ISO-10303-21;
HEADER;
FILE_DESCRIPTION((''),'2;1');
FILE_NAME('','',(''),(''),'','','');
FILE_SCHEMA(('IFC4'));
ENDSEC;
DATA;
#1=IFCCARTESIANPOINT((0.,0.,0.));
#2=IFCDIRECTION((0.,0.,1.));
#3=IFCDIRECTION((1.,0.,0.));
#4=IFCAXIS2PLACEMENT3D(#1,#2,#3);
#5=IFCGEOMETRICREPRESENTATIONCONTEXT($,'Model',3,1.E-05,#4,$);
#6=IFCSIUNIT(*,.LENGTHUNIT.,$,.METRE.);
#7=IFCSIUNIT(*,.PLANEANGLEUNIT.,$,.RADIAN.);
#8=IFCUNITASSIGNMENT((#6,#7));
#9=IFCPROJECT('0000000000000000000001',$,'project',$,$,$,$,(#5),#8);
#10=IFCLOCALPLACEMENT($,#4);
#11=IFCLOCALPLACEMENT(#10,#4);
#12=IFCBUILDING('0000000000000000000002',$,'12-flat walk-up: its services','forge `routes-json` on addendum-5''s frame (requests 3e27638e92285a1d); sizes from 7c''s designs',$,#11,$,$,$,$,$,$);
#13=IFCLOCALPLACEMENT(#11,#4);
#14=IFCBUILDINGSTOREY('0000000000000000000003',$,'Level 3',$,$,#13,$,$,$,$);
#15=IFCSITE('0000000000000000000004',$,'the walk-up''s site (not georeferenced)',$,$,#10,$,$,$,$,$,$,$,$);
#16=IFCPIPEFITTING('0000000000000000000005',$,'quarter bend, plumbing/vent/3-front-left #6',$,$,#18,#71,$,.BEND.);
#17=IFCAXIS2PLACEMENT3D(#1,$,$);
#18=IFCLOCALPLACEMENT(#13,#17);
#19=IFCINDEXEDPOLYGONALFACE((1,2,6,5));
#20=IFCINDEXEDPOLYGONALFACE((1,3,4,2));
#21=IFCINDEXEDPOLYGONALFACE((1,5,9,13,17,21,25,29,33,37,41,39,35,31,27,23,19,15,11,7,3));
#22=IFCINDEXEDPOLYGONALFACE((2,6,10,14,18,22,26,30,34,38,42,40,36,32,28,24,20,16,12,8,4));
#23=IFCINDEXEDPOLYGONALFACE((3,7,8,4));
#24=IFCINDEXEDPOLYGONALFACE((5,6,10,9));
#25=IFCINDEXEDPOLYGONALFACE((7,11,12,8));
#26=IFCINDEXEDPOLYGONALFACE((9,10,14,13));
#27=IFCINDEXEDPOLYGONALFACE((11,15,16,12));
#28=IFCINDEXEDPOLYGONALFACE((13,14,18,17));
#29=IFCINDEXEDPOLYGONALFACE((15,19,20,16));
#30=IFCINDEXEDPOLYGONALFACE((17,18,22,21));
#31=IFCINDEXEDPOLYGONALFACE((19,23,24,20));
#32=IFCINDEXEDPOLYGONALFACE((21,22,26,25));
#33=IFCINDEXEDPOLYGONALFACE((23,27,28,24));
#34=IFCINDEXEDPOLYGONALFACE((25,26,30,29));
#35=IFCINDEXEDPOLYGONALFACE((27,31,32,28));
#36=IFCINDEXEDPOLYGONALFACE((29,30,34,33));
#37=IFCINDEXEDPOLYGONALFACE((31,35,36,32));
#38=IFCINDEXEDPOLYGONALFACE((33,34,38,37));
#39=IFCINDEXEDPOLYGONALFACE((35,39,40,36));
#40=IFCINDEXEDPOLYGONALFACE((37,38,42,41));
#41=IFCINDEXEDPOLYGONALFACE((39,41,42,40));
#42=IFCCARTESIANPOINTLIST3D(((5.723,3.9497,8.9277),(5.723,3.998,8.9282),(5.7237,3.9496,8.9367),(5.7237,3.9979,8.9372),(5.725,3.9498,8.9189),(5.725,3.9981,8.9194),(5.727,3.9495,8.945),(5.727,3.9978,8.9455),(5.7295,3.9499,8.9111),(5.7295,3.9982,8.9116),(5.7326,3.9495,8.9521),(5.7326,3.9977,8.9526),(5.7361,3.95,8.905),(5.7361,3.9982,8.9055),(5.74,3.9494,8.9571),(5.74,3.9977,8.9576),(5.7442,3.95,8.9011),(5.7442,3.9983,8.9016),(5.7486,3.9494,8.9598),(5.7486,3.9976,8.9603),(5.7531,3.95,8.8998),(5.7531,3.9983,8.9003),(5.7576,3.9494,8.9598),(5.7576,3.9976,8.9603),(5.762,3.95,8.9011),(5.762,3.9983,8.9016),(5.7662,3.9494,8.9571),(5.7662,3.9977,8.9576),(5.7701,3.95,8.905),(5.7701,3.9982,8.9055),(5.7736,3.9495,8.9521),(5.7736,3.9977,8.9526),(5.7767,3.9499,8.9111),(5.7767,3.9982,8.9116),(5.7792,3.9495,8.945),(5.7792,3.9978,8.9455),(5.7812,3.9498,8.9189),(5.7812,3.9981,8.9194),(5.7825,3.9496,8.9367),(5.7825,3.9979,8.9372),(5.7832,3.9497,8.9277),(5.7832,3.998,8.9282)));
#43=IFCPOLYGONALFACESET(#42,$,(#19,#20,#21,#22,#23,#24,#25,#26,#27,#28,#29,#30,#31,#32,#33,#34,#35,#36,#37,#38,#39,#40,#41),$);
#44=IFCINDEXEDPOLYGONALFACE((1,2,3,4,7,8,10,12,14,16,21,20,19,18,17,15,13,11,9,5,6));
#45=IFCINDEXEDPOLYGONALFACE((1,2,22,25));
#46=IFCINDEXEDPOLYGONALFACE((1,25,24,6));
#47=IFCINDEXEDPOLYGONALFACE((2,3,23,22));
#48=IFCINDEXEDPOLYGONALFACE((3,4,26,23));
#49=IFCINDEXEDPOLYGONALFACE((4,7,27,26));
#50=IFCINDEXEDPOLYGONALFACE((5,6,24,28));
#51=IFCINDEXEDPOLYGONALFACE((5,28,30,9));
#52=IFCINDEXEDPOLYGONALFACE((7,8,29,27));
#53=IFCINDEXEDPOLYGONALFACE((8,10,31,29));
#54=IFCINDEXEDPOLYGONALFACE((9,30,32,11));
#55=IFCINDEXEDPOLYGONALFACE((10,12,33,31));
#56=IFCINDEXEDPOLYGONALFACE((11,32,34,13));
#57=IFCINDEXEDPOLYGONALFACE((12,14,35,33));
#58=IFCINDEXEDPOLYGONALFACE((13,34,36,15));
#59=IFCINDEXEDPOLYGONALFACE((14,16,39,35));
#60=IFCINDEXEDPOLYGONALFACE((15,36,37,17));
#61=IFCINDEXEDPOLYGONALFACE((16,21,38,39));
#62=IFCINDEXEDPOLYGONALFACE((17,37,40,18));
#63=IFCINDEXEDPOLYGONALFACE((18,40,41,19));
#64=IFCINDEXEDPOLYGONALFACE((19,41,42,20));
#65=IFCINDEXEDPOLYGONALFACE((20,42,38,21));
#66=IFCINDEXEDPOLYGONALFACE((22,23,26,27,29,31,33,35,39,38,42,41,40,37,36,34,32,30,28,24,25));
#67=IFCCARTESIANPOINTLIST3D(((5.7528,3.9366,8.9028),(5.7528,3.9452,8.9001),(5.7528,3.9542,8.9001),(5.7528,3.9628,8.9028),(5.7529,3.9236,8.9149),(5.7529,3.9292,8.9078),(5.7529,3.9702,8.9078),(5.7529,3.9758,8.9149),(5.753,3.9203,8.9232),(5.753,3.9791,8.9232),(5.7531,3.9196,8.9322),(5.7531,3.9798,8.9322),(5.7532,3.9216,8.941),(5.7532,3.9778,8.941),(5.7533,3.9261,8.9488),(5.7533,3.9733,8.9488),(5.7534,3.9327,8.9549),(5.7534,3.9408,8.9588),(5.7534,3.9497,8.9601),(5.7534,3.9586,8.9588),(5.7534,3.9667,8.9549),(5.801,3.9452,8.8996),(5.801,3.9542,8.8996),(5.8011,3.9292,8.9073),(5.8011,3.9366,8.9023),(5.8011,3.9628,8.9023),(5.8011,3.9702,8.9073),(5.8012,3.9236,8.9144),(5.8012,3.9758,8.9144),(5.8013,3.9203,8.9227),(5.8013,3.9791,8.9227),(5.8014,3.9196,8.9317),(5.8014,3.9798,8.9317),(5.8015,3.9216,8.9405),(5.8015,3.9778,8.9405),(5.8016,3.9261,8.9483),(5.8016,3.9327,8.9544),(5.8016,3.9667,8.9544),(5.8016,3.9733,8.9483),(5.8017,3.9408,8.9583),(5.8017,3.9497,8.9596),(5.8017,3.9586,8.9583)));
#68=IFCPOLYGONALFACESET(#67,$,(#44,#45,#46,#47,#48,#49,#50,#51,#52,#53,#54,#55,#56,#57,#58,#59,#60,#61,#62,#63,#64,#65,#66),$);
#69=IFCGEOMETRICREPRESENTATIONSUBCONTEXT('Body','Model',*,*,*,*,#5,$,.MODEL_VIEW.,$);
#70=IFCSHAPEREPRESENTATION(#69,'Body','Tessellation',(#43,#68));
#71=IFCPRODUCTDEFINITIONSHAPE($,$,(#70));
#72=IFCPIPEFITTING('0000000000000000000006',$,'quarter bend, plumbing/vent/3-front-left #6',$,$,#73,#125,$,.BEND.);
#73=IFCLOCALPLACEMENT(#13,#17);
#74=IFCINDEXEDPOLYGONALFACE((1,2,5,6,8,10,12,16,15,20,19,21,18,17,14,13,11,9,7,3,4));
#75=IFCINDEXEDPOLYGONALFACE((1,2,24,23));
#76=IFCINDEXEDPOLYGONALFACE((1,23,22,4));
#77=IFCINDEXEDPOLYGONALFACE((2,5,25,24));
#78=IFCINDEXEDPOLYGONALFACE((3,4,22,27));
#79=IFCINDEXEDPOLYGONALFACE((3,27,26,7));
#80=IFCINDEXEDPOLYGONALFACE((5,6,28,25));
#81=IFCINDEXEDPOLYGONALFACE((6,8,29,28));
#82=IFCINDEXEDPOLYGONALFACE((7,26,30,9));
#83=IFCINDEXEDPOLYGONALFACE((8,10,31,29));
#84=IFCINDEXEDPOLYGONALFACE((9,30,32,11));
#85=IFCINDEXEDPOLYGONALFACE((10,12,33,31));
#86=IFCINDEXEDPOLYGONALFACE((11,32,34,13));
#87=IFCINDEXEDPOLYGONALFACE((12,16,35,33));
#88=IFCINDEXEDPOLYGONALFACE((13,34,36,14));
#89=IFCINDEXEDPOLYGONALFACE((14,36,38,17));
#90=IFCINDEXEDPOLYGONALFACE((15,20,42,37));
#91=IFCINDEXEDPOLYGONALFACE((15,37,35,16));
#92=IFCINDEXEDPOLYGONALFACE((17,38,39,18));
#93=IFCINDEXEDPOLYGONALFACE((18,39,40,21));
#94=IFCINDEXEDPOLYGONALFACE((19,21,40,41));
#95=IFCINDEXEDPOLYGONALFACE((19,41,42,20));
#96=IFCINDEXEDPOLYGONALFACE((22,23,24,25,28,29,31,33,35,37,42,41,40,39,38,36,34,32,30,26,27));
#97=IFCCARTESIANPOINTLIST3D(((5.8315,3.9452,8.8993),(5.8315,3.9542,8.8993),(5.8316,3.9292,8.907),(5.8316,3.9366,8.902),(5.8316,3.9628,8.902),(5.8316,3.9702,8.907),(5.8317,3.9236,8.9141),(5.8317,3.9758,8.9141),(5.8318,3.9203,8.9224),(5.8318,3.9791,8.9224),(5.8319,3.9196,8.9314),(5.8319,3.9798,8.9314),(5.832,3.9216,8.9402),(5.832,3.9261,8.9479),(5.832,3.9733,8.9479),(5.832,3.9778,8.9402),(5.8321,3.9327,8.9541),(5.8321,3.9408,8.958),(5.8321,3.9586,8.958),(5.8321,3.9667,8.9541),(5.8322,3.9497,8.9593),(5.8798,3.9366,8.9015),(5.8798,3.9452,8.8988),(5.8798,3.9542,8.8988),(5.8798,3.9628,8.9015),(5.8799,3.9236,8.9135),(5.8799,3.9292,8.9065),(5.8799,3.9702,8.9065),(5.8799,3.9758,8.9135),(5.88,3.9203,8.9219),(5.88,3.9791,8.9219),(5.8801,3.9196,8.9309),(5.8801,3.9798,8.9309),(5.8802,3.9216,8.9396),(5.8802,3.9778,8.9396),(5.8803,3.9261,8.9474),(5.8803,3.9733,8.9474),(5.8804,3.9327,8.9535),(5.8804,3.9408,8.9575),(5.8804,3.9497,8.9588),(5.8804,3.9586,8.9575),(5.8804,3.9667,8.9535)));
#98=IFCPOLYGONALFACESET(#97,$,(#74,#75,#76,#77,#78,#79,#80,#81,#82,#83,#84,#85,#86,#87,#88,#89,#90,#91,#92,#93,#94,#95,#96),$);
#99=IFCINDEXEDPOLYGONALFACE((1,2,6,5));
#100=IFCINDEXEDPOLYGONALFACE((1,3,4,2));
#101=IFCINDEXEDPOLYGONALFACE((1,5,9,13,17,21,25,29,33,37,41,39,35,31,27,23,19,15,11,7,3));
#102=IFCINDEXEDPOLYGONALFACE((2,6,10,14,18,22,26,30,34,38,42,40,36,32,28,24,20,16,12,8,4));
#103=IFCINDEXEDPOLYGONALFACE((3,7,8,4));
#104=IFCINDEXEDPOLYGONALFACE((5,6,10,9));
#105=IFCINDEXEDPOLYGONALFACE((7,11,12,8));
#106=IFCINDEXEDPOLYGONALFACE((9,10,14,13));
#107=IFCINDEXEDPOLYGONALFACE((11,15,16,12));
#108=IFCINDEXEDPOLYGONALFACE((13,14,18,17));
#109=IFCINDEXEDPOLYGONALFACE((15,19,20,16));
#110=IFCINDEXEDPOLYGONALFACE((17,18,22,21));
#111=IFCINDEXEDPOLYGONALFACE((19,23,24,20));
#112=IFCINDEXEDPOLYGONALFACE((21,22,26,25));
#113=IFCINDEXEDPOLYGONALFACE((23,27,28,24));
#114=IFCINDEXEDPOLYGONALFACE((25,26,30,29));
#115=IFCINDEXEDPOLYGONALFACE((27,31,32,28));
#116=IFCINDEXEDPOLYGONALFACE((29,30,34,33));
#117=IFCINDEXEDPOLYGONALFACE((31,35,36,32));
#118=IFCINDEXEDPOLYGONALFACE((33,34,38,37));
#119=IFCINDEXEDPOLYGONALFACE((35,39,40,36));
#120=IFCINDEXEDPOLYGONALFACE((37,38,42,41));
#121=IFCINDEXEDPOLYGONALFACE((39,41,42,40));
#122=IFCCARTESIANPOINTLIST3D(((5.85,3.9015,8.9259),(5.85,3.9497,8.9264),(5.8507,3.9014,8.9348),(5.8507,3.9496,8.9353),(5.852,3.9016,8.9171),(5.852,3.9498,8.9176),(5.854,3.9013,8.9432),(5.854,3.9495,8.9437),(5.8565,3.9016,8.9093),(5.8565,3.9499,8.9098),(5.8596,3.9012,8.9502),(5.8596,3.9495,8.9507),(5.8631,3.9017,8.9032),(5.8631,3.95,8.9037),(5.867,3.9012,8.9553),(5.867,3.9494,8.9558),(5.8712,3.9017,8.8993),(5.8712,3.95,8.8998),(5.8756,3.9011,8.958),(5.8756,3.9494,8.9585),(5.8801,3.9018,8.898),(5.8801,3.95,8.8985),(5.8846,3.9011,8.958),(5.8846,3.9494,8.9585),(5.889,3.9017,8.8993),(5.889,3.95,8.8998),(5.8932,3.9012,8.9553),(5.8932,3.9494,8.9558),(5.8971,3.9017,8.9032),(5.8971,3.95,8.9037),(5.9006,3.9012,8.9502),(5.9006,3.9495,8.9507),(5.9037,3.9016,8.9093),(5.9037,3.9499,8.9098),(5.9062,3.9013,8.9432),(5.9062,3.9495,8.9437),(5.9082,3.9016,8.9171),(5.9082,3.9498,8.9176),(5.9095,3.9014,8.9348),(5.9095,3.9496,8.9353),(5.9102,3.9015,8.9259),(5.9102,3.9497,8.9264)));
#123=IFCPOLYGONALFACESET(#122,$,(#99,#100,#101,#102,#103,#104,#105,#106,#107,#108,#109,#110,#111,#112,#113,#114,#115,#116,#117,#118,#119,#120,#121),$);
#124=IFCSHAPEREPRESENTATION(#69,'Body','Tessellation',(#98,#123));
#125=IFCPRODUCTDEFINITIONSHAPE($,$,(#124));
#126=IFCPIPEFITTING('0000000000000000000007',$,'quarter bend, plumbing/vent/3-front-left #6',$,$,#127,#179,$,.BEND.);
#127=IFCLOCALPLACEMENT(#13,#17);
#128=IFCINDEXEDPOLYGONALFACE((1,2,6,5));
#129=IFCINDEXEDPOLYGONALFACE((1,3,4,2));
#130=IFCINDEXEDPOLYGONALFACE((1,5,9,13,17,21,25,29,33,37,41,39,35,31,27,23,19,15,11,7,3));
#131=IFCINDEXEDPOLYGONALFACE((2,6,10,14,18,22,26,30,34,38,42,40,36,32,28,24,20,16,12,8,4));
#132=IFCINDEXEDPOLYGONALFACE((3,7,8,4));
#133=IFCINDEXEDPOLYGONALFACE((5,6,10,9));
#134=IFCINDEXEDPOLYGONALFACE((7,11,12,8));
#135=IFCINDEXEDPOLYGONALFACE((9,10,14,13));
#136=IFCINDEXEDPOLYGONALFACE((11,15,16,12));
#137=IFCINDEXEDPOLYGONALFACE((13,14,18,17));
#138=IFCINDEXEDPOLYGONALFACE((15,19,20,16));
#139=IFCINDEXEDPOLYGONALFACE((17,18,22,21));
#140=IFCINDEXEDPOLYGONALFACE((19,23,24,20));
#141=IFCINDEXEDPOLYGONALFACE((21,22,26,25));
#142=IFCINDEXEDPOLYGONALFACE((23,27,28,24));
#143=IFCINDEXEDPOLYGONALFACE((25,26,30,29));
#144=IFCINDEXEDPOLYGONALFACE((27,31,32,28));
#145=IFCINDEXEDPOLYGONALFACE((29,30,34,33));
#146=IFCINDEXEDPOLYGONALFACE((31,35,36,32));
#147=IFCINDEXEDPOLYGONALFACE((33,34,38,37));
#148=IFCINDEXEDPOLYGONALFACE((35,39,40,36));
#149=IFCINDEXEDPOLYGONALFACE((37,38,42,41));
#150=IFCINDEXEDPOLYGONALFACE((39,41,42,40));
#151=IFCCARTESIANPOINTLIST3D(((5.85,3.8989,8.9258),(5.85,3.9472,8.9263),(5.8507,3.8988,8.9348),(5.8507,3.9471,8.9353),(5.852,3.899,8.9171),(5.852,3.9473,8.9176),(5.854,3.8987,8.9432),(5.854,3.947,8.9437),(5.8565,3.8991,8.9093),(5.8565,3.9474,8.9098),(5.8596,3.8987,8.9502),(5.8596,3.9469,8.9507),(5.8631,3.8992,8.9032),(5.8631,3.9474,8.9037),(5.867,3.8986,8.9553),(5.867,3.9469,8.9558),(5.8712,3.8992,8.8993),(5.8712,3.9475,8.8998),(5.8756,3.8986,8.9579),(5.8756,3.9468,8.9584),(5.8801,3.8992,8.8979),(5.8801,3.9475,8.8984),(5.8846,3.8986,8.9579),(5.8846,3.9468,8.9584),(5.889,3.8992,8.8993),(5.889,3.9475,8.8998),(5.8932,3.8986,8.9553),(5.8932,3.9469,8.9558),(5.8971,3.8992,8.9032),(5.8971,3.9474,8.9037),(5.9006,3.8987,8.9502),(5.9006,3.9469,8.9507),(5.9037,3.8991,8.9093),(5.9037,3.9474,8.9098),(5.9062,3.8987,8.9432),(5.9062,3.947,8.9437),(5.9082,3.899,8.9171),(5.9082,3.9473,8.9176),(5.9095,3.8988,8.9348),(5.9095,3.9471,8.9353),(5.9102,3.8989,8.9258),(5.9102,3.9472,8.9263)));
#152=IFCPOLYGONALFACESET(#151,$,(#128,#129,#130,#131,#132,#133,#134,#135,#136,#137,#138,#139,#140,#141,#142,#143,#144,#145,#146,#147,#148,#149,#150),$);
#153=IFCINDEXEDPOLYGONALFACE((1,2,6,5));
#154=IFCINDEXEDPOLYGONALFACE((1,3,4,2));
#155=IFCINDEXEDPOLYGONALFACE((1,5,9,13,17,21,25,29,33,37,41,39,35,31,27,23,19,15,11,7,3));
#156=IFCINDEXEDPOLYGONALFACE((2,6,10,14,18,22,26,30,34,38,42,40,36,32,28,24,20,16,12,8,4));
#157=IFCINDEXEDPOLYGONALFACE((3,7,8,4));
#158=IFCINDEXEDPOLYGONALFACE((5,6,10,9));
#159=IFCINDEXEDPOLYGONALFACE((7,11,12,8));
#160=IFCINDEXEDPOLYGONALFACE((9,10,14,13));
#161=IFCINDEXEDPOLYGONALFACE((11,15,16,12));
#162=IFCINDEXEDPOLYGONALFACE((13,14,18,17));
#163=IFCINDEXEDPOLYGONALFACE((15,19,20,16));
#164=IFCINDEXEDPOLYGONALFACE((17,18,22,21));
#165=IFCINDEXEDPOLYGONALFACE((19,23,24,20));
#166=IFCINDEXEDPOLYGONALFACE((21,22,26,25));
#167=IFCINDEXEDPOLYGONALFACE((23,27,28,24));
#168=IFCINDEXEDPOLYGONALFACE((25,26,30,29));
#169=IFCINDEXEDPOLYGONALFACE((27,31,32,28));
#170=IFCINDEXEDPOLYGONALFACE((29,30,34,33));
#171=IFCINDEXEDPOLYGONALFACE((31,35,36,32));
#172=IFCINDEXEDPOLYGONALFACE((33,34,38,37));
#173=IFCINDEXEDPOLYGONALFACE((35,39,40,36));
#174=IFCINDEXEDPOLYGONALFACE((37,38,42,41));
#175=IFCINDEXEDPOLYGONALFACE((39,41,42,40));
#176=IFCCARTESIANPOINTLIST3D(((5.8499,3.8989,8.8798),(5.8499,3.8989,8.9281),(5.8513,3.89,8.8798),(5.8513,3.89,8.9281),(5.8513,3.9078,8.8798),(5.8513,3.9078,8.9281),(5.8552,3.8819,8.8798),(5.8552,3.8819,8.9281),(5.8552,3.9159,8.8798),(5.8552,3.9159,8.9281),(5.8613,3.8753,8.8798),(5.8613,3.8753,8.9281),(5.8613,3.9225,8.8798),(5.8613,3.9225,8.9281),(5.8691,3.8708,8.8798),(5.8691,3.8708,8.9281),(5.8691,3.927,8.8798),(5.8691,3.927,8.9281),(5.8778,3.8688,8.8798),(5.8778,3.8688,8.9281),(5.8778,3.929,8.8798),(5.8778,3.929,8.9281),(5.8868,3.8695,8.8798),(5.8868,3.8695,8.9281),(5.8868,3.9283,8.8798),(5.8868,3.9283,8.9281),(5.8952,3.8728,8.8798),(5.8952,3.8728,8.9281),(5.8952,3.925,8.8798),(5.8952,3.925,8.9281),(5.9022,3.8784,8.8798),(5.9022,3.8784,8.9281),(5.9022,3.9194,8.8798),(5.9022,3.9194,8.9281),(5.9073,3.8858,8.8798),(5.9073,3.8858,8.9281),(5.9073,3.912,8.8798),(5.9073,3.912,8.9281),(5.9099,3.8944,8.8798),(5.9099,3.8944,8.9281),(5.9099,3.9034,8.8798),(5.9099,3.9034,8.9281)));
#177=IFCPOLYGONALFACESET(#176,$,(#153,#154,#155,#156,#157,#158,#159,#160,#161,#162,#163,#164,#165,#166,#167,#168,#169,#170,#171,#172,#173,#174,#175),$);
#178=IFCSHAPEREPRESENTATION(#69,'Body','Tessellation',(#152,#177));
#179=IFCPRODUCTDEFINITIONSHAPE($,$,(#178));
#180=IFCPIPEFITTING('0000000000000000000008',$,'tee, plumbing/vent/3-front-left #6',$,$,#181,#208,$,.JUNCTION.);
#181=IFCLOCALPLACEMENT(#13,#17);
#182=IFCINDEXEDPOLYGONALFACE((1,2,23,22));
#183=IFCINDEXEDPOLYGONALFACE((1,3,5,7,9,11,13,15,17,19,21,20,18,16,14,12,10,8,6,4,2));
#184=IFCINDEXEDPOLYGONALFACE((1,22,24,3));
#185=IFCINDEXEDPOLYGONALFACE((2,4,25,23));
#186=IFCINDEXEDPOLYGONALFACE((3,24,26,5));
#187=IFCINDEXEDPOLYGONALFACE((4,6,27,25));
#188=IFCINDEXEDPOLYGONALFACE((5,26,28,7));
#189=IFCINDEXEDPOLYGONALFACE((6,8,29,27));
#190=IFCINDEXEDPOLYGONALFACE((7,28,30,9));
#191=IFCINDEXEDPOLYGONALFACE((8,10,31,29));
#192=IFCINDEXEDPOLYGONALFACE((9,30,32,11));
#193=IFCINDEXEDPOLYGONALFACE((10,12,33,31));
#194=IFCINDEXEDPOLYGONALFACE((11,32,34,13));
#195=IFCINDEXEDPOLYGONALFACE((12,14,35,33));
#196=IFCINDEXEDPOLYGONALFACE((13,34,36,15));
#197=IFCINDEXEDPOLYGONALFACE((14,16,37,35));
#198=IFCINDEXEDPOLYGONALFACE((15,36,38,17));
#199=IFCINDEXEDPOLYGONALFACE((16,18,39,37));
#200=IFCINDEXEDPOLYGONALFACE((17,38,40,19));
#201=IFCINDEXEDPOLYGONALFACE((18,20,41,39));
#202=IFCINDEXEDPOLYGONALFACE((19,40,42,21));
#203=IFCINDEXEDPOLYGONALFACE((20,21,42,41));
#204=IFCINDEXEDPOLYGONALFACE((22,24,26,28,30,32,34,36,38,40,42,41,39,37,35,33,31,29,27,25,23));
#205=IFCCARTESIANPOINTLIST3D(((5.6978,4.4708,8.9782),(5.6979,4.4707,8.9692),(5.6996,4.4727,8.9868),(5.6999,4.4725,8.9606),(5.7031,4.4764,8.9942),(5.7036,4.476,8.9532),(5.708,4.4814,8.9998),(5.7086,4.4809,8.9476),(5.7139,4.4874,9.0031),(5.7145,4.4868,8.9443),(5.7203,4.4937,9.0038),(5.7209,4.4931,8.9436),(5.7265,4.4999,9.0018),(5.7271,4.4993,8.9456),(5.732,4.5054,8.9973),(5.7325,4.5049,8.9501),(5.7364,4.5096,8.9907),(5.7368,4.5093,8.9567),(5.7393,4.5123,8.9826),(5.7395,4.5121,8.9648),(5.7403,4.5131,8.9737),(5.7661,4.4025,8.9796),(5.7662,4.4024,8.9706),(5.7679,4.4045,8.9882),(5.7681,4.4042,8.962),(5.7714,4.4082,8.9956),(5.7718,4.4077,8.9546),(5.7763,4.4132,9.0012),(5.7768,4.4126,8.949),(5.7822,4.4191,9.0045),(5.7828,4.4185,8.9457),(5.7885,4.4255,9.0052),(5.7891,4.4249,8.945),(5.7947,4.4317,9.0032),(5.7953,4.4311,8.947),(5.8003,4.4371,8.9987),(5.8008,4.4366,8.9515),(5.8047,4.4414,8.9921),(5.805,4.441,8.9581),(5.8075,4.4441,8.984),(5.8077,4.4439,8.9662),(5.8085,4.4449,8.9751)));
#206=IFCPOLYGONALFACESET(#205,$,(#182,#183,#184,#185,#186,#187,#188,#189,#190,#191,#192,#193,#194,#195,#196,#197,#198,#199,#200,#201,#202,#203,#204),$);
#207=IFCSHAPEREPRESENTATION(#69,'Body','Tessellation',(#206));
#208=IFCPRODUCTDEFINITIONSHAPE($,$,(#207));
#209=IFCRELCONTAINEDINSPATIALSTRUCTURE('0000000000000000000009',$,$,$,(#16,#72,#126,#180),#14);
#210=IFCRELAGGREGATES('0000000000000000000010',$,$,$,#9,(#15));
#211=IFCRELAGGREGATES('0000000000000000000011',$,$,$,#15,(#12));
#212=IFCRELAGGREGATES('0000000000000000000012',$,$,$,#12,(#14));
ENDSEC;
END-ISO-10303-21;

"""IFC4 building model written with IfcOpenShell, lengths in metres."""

from ifc_helpers import new_model, entity, si_unit, frame, origin_with_axes, place, context, subcontext, project, spatial, element, save


model = new_model("IFC4")

# Units and contexts
model_context = context("Model", 3, precision=1e-05, world=origin_with_axes())
body_context = subcontext(model_context, "Body", "Model", "MODEL_VIEW")
ifc_project = project(units=[si_unit("LENGTHUNIT", "METRE"), si_unit("PLANEANGLEUNIT", "RADIAN")], contexts=[model_context])

# Site, building, storey
site_placement = place(None, origin_with_axes())
site = spatial("IfcSite", under=ifc_project, at=site_placement, Name="the walk-up's site (not georeferenced)")
building_placement = place(site_placement, origin_with_axes())
building = spatial("IfcBuilding", under=site, at=building_placement, Name="12-flat walk-up: its services", Description="forge `routes-json` on addendum-5's frame (requests 3e27638e92285a1d); sizes from 7c's designs")
storey_placement = place(building_placement, origin_with_axes())
storey = spatial("IfcBuildingStorey", under=building, at=storey_placement, Name="Level 3")

# Pipe fittings
pipe_fitting_1_placement = place(storey_placement, frame((5.7531, 3.998, 8.9305), z_axis=(0.0, 0.0, 1.0), x_axis=(1.0, 0.0, 0.0)))
element("IfcPipeFitting", 1, at=pipe_fitting_1_placement, inside=storey, Name="quarter bend, plumbing/vent/3-front-left #6", PredefinedType="BEND", context=body_context, shape_type="AdvancedSweptSolid", body=[
    entity("IfcSweptDiskSolid", entity("IfcPolyline", [entity("IfcCartesianPoint", [0.0, 0.0, 0.0]), entity("IfcCartesianPoint", [0.0, -0.0483, -0.0005])]), 0.0302),
    entity("IfcSweptDiskSolid", entity("IfcPolyline", [entity("IfcCartesianPoint", [0.0, -0.0483, -0.0005]), entity("IfcCartesianPoint", [0.0483, -0.0483, -0.001])]), 0.0302),
])
pipe_fitting_2_placement = place(storey_placement, frame((5.8318, 3.9497, 8.9291), z_axis=(0.0, 0.0, 1.0), x_axis=(1.0, 0.0, 0.0)))
element("IfcPipeFitting", 2, at=pipe_fitting_2_placement, inside=storey, Name="quarter bend, plumbing/vent/3-front-left #6", PredefinedType="BEND", context=body_context, shape_type="AdvancedSweptSolid", body=[
    entity("IfcSweptDiskSolid", entity("IfcPolyline", [entity("IfcCartesianPoint", [0.0, 0.0, 0.0]), entity("IfcCartesianPoint", [0.0483, 0.0, -0.0005])]), 0.0302),
    entity("IfcSweptDiskSolid", entity("IfcPolyline", [entity("IfcCartesianPoint", [0.0483, 0.0, -0.0005]), entity("IfcCartesianPoint", [0.0483, -0.0483, -0.001])]), 0.0302),
])
pipe_fitting_3_placement = place(storey_placement, frame((5.8801, 3.9472, 8.9286), z_axis=(0.0, 0.0, 1.0), x_axis=(1.0, 0.0, 0.0)))
element("IfcPipeFitting", 3, at=pipe_fitting_3_placement, inside=storey, Name="quarter bend, plumbing/vent/3-front-left #6", PredefinedType="BEND", context=body_context, shape_type="AdvancedSweptSolid", body=[
    entity("IfcSweptDiskSolid", entity("IfcPolyline", [entity("IfcCartesianPoint", [0.0, 0.0, 0.0]), entity("IfcCartesianPoint", [0.0, -0.0483, -0.0005])]), 0.0302),
    entity("IfcSweptDiskSolid", entity("IfcPolyline", [entity("IfcCartesianPoint", [0.0, -0.0483, -0.0005]), entity("IfcCartesianPoint", [0.0, -0.0483, -0.0488])]), 0.0302),
])
pipe_fitting_4_placement = place(storey_placement, frame((5.7872, 4.4236, 8.9751), z_axis=(0.0, 0.0, 1.0), x_axis=(1.0, 0.0, 0.0)))
element("IfcPipeFitting", 4, at=pipe_fitting_4_placement, inside=storey, Name="tee, plumbing/vent/3-front-left #6", PredefinedType="JUNCTION", context=body_context, shape_type="AdvancedSweptSolid", body=[
    entity("IfcSweptDiskSolid", entity("IfcPolyline", [entity("IfcCartesianPoint", [0.0, 0.0, 0.0]), entity("IfcCartesianPoint", [-0.0682, 0.0682, -0.0014])]), 0.0302),
])

save(model, "model.ifc")
